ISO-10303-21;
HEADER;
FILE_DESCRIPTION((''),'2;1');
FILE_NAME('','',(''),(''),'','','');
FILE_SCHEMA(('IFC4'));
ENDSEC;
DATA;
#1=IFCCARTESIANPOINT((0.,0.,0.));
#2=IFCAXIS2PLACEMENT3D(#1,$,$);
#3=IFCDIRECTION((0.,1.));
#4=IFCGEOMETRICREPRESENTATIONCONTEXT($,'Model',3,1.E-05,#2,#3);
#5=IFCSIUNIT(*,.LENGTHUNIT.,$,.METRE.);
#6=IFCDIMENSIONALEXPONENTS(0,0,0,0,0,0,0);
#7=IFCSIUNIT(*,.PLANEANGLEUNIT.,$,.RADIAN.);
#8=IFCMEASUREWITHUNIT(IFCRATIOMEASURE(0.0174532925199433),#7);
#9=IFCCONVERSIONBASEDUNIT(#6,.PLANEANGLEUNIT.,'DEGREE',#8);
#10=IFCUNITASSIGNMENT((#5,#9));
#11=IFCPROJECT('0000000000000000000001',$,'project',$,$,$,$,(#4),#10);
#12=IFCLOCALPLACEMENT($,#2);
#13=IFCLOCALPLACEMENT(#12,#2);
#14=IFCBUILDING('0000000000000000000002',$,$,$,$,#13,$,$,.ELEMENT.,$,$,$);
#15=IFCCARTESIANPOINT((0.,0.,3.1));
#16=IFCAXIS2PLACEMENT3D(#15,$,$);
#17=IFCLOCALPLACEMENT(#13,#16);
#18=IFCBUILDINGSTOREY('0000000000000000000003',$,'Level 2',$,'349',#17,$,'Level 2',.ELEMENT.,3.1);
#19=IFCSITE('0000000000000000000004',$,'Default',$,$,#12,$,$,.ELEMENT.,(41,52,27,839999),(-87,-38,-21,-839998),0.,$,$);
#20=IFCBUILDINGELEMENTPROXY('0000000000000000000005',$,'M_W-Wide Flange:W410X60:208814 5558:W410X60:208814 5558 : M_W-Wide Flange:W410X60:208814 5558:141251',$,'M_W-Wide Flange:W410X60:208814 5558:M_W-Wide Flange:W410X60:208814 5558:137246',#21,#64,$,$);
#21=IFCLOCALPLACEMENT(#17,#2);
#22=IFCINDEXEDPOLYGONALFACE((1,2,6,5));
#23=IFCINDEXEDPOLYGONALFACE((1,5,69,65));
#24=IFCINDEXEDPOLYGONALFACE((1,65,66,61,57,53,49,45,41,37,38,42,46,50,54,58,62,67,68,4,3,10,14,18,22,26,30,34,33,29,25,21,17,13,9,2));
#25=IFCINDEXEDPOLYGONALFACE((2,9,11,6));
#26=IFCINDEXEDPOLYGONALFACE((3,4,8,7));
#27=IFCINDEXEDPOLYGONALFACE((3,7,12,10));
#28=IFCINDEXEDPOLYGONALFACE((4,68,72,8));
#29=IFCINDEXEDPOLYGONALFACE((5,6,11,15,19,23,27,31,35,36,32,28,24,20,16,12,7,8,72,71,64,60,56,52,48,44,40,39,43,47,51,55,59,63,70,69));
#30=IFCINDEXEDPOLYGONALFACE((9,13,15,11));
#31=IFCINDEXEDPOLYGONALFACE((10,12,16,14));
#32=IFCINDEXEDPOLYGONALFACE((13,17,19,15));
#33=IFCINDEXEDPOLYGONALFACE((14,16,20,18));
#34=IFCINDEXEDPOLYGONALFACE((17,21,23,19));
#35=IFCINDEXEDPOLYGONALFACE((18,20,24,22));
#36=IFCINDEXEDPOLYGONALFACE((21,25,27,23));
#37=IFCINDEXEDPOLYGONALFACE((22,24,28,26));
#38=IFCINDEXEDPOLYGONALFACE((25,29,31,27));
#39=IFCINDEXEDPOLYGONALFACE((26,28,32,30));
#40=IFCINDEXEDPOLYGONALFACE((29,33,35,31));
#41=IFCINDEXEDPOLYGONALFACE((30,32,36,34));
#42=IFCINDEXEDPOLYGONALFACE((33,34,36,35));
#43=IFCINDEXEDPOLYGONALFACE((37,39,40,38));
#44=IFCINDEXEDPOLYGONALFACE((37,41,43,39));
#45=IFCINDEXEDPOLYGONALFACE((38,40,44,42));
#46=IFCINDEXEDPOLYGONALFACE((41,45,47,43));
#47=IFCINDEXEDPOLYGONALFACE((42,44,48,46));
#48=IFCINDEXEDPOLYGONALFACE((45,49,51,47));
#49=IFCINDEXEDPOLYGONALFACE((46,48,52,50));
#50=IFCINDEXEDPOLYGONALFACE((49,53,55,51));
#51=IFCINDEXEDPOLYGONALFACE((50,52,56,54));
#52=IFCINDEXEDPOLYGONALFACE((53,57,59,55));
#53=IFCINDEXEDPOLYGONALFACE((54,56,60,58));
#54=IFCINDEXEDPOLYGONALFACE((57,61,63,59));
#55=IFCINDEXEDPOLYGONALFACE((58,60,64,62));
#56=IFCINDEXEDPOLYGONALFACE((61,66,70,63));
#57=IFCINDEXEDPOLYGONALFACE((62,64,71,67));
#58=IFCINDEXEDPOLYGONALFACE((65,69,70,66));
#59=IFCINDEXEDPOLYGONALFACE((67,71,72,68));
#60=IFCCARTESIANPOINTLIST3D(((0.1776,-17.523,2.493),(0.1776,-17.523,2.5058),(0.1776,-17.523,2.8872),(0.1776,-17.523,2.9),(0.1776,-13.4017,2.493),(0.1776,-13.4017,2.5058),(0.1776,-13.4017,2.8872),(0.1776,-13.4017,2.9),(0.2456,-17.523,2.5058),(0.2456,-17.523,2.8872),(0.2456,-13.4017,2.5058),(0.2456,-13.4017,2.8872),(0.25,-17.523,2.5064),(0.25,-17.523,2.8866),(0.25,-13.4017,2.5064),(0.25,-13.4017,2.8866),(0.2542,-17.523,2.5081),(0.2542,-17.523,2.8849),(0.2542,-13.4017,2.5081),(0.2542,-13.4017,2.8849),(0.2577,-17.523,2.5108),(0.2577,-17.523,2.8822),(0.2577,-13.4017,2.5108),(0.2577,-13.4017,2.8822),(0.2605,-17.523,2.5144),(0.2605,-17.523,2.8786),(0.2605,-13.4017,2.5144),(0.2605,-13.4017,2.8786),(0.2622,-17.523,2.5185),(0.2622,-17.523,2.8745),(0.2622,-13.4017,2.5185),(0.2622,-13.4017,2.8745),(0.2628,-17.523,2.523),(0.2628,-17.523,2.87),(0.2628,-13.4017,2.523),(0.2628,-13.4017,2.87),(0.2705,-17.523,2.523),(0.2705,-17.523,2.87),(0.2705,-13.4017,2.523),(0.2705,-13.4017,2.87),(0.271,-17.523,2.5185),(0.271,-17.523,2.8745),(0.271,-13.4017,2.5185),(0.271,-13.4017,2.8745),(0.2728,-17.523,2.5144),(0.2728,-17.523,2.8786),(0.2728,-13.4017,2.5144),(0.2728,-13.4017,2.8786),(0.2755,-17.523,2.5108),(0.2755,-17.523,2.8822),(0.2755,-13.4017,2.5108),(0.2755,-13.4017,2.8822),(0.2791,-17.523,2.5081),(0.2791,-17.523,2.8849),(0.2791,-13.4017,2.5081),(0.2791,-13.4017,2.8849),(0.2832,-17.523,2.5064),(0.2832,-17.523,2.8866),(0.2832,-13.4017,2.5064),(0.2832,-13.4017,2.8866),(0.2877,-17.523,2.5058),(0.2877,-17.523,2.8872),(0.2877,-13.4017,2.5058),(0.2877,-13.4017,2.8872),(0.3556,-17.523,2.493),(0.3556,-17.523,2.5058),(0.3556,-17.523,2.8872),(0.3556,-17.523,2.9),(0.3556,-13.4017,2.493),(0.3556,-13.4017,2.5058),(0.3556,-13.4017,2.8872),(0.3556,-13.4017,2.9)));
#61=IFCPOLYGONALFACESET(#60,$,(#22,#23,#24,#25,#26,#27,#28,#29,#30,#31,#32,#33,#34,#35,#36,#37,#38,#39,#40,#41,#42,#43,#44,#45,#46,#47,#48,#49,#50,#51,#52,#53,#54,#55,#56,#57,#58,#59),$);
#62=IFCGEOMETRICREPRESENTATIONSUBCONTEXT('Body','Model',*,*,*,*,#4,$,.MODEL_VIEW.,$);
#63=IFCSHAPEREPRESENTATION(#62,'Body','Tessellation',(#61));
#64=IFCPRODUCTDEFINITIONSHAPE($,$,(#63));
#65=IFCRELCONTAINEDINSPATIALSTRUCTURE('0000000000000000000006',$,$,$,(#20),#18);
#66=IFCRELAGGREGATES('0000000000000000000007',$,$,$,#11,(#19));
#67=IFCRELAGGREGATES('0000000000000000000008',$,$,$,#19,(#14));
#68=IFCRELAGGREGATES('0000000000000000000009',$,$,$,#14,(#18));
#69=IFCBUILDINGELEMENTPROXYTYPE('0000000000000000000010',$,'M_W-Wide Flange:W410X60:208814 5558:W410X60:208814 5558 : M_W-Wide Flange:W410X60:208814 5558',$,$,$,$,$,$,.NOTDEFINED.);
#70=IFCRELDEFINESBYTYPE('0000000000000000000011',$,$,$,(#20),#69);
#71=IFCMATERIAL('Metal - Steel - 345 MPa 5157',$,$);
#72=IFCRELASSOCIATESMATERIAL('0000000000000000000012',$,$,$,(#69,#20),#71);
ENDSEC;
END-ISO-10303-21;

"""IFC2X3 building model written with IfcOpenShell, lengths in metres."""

from ifc_helpers import new_model, entity, si_unit, converted_unit, direction, frame, frame_2d, origin, place, context, subcontext, project, spatial, i_section, extrude, source, transform, mapped, material, type_object, type_shapes, element, save


model = new_model("IFC2X3")

# Units and contexts
model_context = context("Model", 3, precision=1e-05, world=origin(), true_north=direction((0.0, 1.0)))
body_context = subcontext(model_context, "Body", "Model", "MODEL_VIEW")
ifc_project = project(units=[si_unit("LENGTHUNIT", "METRE"), converted_unit("PLANEANGLEUNIT", "DEGREE", entity("IfcRatioMeasure", 0.0174532925199433), si_unit("PLANEANGLEUNIT", "RADIAN"), dimensions=[0, 0, 0, 0, 0, 0, 0])], contexts=[model_context])

# Site, building, storey
site_placement = place(None, origin())
site = spatial("IfcSite", under=ifc_project, at=site_placement, Name="Default", CompositionType="ELEMENT", RefLatitude=(41, 52, 27, 839999), RefLongitude=(-87, -38, -21, -839998), RefElevation=0.0)
building_placement = place(site_placement, origin())
building = spatial("IfcBuilding", under=site, at=building_placement, CompositionType="ELEMENT")
storey_placement = place(building_placement, frame((0.0, 0.0, 3.1)))
storey = spatial("IfcBuildingStorey", under=building, at=storey_placement, Name="Level 2", ObjectType="349", LongName="Level 2", CompositionType="ELEMENT", Elevation=3.1)

# Building element proxy
ifc_material_1 = material(Name="Metal - Steel - 345 MPa 5157")
building_element_proxy_type_1 = type_object("IfcBuildingElementProxyType", Name="M_W-Wide Flange:W410X60:208814 5558:W410X60:208814 5558 : M_W-Wide Flange:W410X60:208814 5558", PredefinedType="NOTDEFINED", material=ifc_material_1)
shared_shape_1 = source(origin(), body_context, "Body", "SweptSolid", [
    extrude(i_section(OverallWidth=0.178, OverallDepth=0.407, WebThickness=0.0077, FlangeThickness=0.0128, FilletRadius=0.0172, at=frame_2d((0.0, 0.0), x_axis=(0.0, 1.0))), frame((0.0, 0.0, -0.2035), z_axis=(0.0, 1.0, 0.0), x_axis=(0.0, 0.0, 1.0)), (0.0, 0.0, 1.0), 4.1213),
])
type_shapes(building_element_proxy_type_1, [shared_shape_1])
proxy_1_placement = place(storey_placement, frame((0.2666, -13.4017, 2.9), z_axis=(0.0, 0.0, 1.0), x_axis=(-1.0, 0.0, 0.0)))
element("IfcBuildingElementProxy", 1, at=proxy_1_placement, inside=storey, type_object=building_element_proxy_type_1, material=ifc_material_1, Name="M_W-Wide Flange:W410X60:208814 5558:W410X60:208814 5558 : M_W-Wide Flange:W410X60:208814 5558:141251", ObjectType="M_W-Wide Flange:W410X60:208814 5558:M_W-Wide Flange:W410X60:208814 5558:137246", context=body_context, shape_type="MappedRepresentation", body=[
    mapped(shared_shape_1, transform((0.0, 0.0, 0.0), scale=1.0)),
])

save(model, "model.ifc")
